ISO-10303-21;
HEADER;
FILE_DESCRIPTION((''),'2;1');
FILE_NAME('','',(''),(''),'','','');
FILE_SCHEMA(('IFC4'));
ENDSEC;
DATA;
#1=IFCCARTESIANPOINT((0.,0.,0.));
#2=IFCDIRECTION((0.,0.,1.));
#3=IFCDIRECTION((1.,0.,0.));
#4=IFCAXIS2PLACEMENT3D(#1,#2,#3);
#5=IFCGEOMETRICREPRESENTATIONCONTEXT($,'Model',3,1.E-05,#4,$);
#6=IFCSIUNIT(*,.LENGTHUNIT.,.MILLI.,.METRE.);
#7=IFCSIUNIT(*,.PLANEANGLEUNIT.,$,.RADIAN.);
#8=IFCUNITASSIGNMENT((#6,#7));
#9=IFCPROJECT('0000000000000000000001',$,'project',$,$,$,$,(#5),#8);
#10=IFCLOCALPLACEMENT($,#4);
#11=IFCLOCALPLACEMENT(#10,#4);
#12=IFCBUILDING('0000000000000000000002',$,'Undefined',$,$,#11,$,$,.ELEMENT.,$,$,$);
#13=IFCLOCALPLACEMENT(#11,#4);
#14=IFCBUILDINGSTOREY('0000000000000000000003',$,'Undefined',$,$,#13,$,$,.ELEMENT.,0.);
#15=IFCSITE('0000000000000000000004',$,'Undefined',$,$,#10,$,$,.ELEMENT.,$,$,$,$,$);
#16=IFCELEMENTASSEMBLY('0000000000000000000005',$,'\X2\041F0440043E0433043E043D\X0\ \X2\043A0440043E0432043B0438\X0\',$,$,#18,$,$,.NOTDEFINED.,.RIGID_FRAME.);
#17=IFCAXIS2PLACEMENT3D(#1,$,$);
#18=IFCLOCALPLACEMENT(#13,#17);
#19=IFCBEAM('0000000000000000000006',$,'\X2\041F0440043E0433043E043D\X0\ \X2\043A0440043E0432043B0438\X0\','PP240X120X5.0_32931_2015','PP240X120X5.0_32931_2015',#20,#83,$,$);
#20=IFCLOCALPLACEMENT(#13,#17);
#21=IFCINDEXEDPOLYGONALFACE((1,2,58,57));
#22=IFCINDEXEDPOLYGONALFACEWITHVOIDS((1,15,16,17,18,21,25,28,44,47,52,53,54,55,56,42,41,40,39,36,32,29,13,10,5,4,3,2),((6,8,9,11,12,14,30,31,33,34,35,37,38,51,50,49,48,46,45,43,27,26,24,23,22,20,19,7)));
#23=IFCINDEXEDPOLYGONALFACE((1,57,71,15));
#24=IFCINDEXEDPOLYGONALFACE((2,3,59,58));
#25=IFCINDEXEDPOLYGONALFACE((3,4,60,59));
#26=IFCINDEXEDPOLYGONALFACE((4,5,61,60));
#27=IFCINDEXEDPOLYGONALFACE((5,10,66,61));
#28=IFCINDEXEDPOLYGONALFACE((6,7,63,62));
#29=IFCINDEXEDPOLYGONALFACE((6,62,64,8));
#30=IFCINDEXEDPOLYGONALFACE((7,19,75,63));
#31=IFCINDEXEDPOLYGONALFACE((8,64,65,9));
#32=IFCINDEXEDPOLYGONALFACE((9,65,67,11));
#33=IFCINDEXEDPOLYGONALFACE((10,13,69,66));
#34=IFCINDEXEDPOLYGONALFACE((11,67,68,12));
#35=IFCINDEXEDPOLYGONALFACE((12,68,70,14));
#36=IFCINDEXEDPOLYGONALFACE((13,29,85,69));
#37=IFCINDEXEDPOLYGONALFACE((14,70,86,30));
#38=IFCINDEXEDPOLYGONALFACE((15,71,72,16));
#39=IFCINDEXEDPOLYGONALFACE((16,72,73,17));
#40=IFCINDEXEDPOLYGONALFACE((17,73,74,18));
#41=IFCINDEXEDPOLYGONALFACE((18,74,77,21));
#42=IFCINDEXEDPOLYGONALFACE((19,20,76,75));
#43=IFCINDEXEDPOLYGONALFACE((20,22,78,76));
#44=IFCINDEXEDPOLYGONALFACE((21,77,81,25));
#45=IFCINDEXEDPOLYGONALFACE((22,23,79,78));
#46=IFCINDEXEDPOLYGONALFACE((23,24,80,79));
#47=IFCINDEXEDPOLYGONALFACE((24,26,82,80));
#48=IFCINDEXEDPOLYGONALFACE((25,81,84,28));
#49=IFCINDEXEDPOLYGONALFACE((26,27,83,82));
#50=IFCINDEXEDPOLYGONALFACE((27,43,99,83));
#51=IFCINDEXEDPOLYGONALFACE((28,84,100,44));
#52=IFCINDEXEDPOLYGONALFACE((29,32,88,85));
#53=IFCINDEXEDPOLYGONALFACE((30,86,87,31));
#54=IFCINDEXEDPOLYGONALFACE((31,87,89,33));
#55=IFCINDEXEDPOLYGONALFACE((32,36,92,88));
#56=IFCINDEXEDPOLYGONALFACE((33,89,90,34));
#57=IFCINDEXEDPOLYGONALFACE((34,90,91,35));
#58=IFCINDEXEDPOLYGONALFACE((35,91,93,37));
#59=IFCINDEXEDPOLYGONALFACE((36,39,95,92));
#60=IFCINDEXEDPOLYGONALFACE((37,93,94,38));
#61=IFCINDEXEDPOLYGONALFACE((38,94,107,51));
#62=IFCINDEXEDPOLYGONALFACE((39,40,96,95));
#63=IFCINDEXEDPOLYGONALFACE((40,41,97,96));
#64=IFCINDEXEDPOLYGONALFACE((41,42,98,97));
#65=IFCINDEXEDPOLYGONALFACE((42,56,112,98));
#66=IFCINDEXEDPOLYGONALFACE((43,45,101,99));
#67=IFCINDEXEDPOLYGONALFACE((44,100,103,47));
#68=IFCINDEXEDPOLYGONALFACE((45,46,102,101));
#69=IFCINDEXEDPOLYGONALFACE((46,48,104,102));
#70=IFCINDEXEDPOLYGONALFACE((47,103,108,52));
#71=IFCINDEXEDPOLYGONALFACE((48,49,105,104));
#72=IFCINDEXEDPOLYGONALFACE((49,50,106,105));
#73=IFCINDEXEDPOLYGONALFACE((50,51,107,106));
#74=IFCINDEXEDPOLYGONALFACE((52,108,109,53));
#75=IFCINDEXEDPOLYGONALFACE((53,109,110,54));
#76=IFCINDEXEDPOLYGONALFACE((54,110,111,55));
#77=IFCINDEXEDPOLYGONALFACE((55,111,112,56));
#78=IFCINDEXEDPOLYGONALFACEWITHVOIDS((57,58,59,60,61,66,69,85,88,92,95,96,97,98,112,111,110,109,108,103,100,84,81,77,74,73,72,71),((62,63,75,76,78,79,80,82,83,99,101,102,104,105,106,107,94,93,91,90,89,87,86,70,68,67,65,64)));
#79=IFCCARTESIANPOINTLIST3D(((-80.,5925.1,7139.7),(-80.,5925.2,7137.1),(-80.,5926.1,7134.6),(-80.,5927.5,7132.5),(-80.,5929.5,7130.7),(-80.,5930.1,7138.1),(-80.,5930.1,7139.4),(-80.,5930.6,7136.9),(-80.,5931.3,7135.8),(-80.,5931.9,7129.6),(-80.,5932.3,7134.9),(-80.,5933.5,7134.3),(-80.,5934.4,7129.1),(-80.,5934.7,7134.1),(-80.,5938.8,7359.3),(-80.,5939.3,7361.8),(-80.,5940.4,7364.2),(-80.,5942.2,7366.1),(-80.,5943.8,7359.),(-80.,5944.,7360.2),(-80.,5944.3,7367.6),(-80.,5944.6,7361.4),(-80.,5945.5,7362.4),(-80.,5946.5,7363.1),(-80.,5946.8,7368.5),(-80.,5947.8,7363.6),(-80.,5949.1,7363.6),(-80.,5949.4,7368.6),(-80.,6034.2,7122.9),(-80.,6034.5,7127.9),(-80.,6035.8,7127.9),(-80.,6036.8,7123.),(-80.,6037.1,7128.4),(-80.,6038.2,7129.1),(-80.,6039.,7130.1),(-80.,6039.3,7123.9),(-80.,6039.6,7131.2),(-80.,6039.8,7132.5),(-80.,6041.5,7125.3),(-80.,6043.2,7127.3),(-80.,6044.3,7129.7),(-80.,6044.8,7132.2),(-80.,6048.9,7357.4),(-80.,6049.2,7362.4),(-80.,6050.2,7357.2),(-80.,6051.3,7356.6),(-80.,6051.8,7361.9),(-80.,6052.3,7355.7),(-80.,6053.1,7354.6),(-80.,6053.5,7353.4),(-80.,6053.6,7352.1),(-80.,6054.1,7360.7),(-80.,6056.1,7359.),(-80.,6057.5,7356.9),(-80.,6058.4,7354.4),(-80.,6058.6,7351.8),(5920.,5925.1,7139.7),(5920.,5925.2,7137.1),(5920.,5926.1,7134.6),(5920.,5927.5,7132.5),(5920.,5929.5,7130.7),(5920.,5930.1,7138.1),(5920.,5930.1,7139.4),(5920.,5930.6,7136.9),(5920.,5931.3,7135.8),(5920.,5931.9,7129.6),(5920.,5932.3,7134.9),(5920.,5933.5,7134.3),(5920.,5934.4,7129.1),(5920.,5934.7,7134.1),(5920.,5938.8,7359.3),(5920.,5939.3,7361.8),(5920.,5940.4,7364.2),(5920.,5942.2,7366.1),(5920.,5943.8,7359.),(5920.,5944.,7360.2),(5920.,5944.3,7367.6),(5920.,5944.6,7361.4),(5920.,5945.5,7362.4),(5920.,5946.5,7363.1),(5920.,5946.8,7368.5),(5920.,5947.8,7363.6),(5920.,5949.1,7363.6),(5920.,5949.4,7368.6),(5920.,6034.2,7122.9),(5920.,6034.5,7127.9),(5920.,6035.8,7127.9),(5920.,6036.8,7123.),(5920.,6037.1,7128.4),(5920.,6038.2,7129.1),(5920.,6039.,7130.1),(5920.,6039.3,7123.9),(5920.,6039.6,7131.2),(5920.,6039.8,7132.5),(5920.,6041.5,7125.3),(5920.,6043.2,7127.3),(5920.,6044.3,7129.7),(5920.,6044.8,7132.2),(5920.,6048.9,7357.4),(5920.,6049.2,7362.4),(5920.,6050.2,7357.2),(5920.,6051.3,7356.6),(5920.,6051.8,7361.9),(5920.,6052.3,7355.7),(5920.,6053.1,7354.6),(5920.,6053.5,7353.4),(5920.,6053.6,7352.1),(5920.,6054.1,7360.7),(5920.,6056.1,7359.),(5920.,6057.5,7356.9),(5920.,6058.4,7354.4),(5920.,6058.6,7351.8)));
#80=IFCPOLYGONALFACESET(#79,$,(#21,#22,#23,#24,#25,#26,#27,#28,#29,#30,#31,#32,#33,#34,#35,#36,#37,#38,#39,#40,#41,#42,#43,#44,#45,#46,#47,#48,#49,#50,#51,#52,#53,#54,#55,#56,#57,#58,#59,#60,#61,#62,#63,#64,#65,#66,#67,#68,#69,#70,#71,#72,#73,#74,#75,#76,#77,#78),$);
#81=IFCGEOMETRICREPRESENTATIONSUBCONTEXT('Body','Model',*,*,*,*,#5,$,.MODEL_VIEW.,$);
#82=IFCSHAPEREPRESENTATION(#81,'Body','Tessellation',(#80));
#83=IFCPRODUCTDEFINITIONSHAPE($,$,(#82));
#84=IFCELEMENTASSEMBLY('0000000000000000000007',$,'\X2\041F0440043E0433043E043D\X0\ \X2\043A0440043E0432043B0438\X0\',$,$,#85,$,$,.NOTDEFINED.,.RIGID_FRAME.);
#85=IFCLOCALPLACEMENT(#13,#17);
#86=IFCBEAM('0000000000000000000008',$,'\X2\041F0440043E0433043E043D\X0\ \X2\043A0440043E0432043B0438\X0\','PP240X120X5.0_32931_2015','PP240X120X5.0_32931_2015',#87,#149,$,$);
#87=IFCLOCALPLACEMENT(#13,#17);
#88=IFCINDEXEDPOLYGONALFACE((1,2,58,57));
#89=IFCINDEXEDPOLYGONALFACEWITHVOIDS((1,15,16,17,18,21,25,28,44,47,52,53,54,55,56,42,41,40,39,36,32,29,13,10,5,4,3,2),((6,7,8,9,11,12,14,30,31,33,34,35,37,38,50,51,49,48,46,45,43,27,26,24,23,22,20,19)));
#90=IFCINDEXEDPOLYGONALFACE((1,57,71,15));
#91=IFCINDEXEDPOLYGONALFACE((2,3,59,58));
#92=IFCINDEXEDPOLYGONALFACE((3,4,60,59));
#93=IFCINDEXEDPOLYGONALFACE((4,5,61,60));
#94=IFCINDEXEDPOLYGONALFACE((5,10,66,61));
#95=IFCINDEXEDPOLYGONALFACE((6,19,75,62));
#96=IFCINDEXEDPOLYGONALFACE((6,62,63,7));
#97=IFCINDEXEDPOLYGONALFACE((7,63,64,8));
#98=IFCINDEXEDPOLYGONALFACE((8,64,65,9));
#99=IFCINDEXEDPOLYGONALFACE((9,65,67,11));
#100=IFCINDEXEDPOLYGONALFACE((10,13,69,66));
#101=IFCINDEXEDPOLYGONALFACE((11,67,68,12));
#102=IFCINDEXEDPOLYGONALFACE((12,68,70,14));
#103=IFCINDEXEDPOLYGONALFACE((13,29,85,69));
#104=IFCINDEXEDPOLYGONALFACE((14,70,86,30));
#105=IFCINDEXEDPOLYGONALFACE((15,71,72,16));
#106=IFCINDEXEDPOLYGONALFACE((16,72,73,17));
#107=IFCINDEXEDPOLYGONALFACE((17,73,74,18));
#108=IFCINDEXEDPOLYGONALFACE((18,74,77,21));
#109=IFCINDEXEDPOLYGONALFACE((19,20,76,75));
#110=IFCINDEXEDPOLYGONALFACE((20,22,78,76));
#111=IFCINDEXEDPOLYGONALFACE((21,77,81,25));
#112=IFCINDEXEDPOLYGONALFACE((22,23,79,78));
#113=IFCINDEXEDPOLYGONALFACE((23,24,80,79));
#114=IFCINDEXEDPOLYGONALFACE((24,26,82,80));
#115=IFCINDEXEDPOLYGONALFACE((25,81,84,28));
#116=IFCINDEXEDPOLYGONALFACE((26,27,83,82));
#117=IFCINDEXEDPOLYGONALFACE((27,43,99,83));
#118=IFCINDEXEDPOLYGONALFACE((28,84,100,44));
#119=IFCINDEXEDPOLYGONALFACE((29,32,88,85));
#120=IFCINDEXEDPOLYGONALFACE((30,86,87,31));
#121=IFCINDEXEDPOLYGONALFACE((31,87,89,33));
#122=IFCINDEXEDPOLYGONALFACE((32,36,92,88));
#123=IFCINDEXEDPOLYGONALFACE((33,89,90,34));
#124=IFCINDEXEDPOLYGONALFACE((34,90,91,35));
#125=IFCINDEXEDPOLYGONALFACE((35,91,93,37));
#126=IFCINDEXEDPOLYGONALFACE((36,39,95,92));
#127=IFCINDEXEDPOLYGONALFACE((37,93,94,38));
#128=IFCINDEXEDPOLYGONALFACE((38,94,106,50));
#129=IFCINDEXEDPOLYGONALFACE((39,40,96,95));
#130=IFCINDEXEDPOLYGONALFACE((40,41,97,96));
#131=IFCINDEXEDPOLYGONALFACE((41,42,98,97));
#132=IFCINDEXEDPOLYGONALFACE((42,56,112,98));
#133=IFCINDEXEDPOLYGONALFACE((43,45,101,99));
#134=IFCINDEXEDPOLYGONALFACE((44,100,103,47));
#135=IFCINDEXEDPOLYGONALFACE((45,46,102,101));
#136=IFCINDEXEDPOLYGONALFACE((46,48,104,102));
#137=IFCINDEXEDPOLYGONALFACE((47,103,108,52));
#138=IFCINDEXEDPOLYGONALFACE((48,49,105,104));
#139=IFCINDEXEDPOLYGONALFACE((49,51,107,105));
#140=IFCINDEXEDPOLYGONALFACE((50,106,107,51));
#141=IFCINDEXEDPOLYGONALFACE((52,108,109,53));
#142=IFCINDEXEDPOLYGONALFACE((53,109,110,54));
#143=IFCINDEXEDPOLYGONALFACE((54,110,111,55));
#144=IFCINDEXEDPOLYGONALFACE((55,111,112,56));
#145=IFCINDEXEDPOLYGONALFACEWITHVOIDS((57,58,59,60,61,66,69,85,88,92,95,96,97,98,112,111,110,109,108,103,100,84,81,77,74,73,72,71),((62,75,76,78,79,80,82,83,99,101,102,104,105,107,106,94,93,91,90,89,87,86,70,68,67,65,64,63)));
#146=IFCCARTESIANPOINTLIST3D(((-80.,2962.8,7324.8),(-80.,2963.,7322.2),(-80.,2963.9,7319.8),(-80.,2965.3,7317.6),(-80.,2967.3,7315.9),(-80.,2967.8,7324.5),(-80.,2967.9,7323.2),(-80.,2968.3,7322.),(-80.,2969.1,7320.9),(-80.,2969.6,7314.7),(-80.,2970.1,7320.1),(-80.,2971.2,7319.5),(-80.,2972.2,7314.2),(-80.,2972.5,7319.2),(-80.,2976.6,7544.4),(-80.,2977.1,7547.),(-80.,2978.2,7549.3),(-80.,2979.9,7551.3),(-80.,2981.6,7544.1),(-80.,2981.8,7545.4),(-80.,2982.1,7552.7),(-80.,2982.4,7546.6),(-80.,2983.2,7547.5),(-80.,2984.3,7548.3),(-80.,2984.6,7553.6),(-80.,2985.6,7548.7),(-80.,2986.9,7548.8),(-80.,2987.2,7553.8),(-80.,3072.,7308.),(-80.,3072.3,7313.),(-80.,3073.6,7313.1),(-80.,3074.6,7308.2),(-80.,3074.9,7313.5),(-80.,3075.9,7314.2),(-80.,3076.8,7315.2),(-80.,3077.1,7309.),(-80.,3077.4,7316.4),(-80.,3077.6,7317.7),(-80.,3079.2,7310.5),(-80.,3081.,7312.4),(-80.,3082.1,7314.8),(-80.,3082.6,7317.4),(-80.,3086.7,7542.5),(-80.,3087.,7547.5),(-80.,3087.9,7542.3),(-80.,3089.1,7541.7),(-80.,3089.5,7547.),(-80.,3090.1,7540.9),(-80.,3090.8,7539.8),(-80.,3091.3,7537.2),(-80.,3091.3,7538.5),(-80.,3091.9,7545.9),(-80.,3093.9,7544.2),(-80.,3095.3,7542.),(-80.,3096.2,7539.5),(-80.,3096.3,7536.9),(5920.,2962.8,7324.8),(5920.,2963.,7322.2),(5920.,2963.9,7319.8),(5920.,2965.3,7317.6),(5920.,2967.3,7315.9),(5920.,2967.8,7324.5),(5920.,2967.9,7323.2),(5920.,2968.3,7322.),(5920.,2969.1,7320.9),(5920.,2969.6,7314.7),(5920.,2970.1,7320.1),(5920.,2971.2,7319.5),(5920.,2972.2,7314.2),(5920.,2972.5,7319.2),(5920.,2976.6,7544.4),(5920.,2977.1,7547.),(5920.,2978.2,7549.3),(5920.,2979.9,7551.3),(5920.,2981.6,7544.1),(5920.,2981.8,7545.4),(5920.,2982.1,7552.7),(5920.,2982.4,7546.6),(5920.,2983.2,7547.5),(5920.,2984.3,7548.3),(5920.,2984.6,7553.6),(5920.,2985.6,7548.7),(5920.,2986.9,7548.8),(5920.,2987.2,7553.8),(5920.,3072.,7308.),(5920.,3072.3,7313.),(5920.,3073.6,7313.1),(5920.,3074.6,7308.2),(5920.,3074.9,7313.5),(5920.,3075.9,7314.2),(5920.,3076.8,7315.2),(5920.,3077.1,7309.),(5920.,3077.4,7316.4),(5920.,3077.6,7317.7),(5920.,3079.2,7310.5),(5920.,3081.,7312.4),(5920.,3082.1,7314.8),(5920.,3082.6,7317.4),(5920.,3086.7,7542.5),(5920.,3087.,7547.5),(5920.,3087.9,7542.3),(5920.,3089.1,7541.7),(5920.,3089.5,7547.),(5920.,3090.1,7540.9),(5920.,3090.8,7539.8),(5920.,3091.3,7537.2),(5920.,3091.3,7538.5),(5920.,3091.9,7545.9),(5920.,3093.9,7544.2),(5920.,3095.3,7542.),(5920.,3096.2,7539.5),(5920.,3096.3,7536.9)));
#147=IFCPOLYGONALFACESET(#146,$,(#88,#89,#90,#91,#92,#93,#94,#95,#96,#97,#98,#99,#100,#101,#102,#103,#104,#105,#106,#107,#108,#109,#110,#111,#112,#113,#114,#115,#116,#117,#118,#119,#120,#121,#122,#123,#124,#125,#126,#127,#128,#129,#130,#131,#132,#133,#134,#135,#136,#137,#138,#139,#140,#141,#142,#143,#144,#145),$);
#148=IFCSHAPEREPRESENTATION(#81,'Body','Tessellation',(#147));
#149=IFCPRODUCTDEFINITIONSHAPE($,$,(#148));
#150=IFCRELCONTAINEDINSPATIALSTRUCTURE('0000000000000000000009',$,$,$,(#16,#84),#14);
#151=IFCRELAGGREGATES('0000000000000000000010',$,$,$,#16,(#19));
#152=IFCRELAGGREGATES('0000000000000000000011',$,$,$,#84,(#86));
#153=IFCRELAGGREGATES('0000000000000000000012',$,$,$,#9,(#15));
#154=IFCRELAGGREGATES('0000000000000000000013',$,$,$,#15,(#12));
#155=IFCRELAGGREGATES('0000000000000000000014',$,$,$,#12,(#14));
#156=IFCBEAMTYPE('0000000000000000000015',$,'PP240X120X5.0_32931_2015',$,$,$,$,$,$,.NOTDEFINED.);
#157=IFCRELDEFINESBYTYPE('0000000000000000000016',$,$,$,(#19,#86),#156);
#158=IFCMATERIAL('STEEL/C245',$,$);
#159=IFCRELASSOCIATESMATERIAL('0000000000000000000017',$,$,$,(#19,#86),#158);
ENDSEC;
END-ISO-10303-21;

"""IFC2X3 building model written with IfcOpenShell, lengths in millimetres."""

from ifc_helpers import new_model, si_unit, frame, origin_with_axes, origin_2d_with_axis, place, context, subcontext, project, spatial, hollow_rectangle, extrude, material, type_object, element, aggregate, save


model = new_model("IFC2X3")

# Units and contexts
model_context = context("Model", 3, precision=1e-05, world=origin_with_axes())
body_context = subcontext(model_context, "Body", "Model", "MODEL_VIEW")
ifc_project = project(units=[si_unit("LENGTHUNIT", "METRE", prefix="MILLI"), si_unit("PLANEANGLEUNIT", "RADIAN")], contexts=[model_context])

# Site, building, storey
site_placement = place(None, origin_with_axes())
site = spatial("IfcSite", under=ifc_project, at=site_placement, Name="Undefined", CompositionType="ELEMENT")
building_placement = place(site_placement, origin_with_axes())
building = spatial("IfcBuilding", under=site, at=building_placement, Name="Undefined", CompositionType="ELEMENT")
storey_placement = place(building_placement, origin_with_axes())
storey = spatial("IfcBuildingStorey", under=building, at=storey_placement, Name="Undefined", CompositionType="ELEMENT", Elevation=0.0)

# Shared definitions
ifc_material = material(Name="STEEL/C245")

# Element assemblies, beams
assembly_1_placement = place(storey_placement, origin_with_axes())
assembly_1 = element("IfcElementAssembly", 1, at=assembly_1_placement, inside=storey, Name="Прогон кровли", AssemblyPlace="NOTDEFINED", PredefinedType="RIGID_FRAME")
beam_type_1 = type_object("IfcBeamType", Name="PP240X120X5.0_32931_2015", PredefinedType="NOTDEFINED")
beam_1_placement = place(assembly_1_placement, frame((5920.0, 5991.8, 7245.7), z_axis=(0.0, 0.062378, 0.998053), x_axis=(-1.0, 0.0, 0.0)))
beam_1 = element("IfcBeam", 2, at=beam_1_placement, type_object=beam_type_1, material=ifc_material, Name="Прогон кровли", Description="PP240X120X5.0_32931_2015", ObjectType="PP240X120X5.0_32931_2015", context=body_context, shape_type="SweptSolid", body=[
    extrude(hollow_rectangle(XDim=120.0, YDim=240.0, WallThickness=5.0, InnerFilletRadius=5.0, OuterFilletRadius=10.0, at=origin_2d_with_axis()), frame((6000.0, 0.0, 0.0), z_axis=(-1.0, 0.0, 0.0), x_axis=(0.0, -1.0, 0.0)), (0.0, 0.0, 1.0), 6000.0),
])
aggregate(assembly_1, [beam_1])
assembly_2_placement = place(storey_placement, origin_with_axes())
assembly_2 = element("IfcElementAssembly", 3, at=assembly_2_placement, inside=storey, Name="Прогон кровли", AssemblyPlace="NOTDEFINED", PredefinedType="RIGID_FRAME")
beam_2_placement = place(assembly_2_placement, frame((5920.0, 3029.6, 7430.9), z_axis=(0.0, 0.062378, 0.998053), x_axis=(-1.0, 0.0, 0.0)))
beam_2 = element("IfcBeam", 4, at=beam_2_placement, type_object=beam_type_1, material=ifc_material, Name="Прогон кровли", Description="PP240X120X5.0_32931_2015", ObjectType="PP240X120X5.0_32931_2015", context=body_context, shape_type="SweptSolid", body=[
    extrude(hollow_rectangle(XDim=120.0, YDim=240.0, WallThickness=5.0, InnerFilletRadius=5.0, OuterFilletRadius=10.0, at=origin_2d_with_axis()), frame((6000.0, 0.0, 0.0), z_axis=(-1.0, 0.0, 0.0), x_axis=(0.0, -1.0, 0.0)), (0.0, 0.0, 1.0), 6000.0),
])
aggregate(assembly_2, [beam_2])

save(model, "model.ifc")
